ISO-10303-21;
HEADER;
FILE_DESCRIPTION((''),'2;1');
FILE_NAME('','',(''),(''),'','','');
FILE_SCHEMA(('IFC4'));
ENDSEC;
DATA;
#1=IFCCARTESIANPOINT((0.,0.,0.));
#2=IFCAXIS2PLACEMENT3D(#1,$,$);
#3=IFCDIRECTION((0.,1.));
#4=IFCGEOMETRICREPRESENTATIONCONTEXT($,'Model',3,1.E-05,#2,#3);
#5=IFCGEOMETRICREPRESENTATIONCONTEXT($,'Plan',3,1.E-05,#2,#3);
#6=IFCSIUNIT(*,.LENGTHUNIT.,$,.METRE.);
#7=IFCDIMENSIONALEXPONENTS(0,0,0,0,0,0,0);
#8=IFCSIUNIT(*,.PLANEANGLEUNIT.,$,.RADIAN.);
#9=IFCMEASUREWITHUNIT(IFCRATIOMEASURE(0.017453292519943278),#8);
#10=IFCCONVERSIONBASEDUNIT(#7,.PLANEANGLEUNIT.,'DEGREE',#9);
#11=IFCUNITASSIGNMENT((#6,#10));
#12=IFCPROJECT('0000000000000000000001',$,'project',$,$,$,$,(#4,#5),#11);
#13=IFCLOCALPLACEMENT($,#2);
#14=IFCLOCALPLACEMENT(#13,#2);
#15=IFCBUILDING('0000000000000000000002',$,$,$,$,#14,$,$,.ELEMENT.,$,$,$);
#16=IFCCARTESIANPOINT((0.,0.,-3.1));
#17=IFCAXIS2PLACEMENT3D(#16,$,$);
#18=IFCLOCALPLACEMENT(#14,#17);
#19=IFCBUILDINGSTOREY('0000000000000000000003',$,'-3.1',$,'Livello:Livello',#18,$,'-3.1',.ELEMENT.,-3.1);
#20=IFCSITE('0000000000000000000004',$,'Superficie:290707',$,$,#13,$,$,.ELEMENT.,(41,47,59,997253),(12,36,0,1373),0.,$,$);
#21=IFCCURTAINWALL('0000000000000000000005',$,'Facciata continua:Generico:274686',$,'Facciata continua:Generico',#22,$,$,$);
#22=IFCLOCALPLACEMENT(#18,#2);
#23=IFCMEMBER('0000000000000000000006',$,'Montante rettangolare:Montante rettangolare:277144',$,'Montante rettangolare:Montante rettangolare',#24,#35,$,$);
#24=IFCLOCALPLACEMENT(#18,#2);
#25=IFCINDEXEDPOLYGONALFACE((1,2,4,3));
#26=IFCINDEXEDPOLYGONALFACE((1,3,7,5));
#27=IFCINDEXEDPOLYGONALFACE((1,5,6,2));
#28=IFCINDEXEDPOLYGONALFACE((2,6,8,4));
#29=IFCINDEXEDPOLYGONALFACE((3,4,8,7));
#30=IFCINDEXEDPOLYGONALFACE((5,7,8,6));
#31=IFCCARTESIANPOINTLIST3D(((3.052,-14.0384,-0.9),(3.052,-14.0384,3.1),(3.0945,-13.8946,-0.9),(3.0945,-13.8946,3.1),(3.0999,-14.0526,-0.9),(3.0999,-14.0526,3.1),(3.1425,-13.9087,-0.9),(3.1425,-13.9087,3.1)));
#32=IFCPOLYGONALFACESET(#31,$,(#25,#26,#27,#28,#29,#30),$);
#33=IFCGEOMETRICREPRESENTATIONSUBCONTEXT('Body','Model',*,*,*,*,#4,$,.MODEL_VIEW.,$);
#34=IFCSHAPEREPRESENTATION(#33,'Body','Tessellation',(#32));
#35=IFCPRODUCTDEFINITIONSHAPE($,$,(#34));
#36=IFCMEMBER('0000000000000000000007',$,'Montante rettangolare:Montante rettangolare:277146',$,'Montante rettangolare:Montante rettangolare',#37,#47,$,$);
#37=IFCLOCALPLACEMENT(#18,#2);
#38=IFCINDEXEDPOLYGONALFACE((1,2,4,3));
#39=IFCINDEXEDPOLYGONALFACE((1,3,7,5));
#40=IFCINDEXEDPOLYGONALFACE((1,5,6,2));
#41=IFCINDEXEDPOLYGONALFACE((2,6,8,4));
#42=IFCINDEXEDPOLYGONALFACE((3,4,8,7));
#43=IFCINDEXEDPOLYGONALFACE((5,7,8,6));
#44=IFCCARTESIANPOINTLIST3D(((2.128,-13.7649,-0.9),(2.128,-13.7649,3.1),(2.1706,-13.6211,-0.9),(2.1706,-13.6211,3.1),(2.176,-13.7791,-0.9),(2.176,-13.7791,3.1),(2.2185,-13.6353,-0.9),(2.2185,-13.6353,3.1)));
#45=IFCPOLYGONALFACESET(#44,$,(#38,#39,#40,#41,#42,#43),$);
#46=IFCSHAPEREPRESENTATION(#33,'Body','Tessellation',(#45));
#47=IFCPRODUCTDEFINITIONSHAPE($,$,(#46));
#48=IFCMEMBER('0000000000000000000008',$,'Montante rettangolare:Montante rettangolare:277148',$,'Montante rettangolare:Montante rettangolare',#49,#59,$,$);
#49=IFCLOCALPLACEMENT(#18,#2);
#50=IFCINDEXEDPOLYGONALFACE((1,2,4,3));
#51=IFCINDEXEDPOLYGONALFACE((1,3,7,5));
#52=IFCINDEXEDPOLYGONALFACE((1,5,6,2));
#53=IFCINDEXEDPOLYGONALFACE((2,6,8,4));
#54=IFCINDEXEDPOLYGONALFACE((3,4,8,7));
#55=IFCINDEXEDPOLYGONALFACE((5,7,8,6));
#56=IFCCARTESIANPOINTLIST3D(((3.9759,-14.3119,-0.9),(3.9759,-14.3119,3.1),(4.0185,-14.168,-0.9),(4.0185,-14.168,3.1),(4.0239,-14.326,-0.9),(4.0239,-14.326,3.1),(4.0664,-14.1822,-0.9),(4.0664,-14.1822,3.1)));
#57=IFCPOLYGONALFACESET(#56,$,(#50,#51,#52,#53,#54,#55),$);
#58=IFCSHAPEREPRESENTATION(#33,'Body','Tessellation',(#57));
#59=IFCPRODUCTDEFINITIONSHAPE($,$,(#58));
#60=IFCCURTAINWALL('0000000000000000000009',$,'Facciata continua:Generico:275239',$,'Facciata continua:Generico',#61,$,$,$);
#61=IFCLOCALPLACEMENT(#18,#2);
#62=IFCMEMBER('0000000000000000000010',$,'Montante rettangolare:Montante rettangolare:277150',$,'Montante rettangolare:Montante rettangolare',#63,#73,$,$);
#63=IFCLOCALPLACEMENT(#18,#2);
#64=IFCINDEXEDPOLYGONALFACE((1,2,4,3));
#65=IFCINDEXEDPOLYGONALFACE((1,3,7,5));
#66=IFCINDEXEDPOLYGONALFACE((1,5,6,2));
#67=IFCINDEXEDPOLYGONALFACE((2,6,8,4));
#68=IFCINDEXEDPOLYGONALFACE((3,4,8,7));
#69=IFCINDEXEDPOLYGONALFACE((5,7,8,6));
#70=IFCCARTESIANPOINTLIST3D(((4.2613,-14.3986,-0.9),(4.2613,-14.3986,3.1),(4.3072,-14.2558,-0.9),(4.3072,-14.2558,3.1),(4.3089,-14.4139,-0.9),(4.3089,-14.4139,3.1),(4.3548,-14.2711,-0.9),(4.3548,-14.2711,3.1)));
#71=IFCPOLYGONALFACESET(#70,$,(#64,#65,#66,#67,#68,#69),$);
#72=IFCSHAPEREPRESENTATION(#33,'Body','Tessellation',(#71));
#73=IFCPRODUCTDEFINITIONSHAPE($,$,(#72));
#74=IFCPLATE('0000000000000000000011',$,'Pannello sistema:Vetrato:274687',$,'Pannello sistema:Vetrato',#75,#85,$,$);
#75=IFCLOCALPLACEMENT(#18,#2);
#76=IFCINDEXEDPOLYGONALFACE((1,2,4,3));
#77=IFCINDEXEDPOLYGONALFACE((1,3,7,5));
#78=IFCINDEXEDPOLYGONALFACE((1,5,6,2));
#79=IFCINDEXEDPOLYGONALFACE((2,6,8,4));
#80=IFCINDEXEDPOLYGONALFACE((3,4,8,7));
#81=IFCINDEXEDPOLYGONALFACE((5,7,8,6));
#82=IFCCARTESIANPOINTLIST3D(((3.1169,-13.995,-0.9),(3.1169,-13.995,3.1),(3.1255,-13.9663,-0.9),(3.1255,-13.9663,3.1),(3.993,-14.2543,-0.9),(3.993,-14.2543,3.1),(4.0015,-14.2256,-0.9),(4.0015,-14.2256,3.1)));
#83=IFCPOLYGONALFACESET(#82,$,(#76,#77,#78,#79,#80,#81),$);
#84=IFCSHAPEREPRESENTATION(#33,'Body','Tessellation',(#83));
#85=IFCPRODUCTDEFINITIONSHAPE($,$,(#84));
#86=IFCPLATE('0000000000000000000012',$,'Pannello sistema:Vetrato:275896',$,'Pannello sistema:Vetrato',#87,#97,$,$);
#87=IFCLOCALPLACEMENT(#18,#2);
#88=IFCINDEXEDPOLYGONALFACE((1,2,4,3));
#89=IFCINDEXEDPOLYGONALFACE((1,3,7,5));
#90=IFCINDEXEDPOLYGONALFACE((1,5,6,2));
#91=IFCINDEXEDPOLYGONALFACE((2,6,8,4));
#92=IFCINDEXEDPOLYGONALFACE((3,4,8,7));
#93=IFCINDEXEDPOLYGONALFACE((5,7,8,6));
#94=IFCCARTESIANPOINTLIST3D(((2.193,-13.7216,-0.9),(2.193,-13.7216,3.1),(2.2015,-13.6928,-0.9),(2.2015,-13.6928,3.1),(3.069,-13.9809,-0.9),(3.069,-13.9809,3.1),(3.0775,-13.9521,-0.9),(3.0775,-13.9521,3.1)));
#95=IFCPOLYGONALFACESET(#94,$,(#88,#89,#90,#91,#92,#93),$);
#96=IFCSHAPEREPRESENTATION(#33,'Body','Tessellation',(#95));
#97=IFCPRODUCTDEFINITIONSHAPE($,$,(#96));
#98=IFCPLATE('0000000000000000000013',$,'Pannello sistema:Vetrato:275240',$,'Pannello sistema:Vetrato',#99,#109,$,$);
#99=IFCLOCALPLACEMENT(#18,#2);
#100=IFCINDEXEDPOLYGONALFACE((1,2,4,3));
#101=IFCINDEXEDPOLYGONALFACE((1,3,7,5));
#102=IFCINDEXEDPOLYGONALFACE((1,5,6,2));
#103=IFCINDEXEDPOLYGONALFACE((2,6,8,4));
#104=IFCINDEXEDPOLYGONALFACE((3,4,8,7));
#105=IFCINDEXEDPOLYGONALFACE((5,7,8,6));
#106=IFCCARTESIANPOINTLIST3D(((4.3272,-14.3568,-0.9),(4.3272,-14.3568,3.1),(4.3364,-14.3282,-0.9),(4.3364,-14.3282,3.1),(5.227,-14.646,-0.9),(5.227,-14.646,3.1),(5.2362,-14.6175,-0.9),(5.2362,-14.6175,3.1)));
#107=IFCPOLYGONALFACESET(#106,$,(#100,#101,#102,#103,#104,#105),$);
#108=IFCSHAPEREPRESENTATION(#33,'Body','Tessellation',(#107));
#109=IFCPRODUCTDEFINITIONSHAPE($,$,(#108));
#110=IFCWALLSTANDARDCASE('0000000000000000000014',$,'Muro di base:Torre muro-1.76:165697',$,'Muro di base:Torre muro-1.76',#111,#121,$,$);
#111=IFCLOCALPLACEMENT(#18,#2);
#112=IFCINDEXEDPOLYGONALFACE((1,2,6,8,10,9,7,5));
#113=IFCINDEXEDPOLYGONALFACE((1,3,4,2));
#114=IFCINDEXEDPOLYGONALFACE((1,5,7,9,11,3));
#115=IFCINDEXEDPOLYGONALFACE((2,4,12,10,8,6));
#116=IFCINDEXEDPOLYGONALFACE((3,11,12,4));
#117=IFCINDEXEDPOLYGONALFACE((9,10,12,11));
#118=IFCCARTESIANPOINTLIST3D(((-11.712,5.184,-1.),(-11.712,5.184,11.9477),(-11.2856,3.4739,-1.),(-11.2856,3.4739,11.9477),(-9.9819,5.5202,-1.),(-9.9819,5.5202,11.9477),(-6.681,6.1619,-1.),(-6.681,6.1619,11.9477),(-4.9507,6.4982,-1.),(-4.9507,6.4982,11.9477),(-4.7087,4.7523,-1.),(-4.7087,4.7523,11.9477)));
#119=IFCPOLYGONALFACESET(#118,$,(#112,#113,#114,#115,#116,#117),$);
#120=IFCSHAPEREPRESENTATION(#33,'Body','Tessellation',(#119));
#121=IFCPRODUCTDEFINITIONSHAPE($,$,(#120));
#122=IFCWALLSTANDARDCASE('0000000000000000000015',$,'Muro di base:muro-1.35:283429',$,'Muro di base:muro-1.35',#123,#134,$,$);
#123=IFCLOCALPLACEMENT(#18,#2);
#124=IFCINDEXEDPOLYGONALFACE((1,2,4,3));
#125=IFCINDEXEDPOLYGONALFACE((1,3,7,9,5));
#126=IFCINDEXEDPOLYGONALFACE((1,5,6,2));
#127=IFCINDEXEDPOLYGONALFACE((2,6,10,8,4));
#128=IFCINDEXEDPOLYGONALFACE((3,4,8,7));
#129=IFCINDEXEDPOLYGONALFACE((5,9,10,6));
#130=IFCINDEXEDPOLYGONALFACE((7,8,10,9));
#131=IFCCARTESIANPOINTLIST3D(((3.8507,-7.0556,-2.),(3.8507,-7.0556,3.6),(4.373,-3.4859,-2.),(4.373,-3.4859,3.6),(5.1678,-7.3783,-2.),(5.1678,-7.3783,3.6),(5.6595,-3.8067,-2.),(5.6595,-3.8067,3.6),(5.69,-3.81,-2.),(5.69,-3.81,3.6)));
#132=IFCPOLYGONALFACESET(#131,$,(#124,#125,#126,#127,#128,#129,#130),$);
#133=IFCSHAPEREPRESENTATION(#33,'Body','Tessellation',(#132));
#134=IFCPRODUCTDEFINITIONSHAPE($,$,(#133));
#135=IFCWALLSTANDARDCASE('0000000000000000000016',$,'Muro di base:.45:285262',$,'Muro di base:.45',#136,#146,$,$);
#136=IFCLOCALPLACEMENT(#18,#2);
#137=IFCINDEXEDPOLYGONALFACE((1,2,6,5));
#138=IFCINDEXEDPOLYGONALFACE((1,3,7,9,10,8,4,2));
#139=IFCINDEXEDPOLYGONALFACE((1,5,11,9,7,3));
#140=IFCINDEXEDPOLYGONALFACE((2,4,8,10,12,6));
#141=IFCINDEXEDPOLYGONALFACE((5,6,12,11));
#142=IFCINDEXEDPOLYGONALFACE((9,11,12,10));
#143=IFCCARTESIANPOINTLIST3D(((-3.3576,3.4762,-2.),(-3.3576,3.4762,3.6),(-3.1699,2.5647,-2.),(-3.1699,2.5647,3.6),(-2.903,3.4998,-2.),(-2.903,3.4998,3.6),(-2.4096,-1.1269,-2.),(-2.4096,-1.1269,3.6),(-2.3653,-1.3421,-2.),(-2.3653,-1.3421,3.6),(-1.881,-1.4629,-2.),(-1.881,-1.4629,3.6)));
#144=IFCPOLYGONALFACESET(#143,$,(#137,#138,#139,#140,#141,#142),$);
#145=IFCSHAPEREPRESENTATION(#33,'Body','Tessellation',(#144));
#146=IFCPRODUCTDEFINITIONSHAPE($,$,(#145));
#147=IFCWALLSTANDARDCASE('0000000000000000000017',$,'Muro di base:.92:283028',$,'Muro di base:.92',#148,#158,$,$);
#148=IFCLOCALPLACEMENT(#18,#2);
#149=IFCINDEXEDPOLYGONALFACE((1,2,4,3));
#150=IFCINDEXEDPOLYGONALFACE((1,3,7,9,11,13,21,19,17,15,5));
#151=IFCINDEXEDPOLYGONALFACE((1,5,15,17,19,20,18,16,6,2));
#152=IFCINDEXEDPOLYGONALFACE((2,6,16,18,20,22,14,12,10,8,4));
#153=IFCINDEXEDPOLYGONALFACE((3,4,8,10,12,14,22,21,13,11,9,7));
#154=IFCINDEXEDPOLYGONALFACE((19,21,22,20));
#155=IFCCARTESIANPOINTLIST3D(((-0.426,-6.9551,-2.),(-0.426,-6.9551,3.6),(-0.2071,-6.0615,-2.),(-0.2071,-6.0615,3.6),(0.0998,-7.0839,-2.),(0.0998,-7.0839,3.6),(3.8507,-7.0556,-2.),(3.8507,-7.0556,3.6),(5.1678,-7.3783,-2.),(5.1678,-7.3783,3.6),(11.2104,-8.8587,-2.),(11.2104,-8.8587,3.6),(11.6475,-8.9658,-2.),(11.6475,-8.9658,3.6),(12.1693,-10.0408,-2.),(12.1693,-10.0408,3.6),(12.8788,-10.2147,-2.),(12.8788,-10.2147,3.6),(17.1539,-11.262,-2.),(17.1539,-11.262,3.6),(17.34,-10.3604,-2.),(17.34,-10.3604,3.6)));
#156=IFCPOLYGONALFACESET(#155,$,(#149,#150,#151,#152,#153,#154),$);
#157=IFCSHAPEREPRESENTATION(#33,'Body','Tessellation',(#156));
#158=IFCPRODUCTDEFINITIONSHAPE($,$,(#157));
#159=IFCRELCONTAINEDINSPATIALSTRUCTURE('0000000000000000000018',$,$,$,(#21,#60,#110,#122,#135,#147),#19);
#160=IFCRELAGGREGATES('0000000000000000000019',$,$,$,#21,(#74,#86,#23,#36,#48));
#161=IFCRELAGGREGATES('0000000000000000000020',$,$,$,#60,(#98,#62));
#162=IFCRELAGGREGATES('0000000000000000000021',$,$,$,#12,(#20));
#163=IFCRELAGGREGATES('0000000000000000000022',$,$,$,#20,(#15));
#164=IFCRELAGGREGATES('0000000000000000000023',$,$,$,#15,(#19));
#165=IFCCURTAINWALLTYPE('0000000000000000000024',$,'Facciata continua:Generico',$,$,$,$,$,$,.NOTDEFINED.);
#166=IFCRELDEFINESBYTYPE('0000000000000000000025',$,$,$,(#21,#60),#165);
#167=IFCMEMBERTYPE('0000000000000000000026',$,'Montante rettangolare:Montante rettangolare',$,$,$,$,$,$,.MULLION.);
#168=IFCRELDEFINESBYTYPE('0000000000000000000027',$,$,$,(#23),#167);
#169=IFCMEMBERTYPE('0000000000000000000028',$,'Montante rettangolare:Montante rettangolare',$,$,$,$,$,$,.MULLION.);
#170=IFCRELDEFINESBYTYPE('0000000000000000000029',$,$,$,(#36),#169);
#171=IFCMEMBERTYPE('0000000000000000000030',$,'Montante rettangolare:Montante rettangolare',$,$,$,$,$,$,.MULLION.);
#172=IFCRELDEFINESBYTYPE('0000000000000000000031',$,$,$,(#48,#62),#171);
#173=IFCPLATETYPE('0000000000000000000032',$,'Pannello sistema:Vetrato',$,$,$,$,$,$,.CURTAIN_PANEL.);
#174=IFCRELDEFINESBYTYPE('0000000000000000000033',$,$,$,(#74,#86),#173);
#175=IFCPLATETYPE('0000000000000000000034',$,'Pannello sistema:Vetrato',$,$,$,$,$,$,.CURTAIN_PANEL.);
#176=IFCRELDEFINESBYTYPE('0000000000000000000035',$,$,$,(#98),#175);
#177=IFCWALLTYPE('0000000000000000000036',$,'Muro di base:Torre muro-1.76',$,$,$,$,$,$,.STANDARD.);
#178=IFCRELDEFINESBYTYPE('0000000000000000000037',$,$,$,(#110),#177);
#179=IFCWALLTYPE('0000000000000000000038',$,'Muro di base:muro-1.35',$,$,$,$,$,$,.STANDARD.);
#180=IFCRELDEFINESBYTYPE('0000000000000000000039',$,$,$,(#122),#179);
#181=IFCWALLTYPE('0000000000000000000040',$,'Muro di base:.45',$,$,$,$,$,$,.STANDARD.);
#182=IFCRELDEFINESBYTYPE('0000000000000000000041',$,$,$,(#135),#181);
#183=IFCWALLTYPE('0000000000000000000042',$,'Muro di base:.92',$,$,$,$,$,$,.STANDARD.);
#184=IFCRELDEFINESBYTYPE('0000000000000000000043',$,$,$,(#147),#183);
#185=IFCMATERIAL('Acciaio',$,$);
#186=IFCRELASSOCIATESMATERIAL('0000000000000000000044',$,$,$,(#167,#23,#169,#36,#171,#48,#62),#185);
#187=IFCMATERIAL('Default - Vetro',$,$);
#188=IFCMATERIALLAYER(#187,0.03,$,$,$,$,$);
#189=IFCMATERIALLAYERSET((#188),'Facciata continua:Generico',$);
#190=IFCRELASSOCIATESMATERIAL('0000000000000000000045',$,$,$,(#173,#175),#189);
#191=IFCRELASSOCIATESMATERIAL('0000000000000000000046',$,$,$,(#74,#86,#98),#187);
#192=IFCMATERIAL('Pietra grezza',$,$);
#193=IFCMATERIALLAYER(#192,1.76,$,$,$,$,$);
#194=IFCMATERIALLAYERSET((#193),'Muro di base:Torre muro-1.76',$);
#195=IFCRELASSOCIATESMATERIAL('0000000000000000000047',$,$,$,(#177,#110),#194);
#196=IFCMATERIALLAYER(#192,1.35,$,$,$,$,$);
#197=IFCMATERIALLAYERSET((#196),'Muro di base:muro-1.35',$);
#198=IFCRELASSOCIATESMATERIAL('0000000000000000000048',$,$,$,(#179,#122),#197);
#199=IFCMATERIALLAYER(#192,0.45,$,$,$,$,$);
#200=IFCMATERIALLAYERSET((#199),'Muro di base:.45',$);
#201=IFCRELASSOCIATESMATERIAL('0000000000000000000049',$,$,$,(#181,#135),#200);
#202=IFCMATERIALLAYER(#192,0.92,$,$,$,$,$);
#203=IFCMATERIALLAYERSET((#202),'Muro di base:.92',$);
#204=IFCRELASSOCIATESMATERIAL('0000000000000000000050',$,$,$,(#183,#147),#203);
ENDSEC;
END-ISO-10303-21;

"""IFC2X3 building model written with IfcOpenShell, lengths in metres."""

from ifc_helpers import new_model, entity, si_unit, converted_unit, direction, frame, frame_2d, origin, origin_2d_with_axis, place, context, subcontext, project, spatial, polyline, rectangle, outline, extrude, source, transform, mapped, material, layer, layer_set, layer_usage, type_object, type_shapes, element, aggregate, save


model = new_model("IFC2X3")

# Units and contexts
model_context = context("Model", 3, precision=1e-05, world=origin(), true_north=direction((0.0, 1.0)))
plan_context = context("Plan", 3, precision=1e-05, world=origin(), true_north=direction((0.0, 1.0)))
body_context = subcontext(model_context, "Body", "Model", "MODEL_VIEW")
ifc_project = project(units=[si_unit("LENGTHUNIT", "METRE"), converted_unit("PLANEANGLEUNIT", "DEGREE", entity("IfcRatioMeasure", 0.017453292519943278), si_unit("PLANEANGLEUNIT", "RADIAN"), dimensions=[0, 0, 0, 0, 0, 0, 0])], contexts=[model_context, plan_context])

# Site, building, storey
site_placement = place(None, origin())
site = spatial("IfcSite", under=ifc_project, at=site_placement, Name="Superficie:290707", CompositionType="ELEMENT", RefLatitude=(41, 47, 59, 997253), RefLongitude=(12, 36, 0, 1373), RefElevation=0.0)
building_placement = place(site_placement, origin())
building = spatial("IfcBuilding", under=site, at=building_placement, CompositionType="ELEMENT")
storey_placement = place(building_placement, frame((0.0, 0.0, -3.1)))
storey = spatial("IfcBuildingStorey", under=building, at=storey_placement, Name="-3.1", ObjectType="Livello:Livello", LongName="-3.1", CompositionType="ELEMENT", Elevation=-3.1)

# Curtain wall, members
curtain_wall_type = type_object("IfcCurtainWallType", Name="Facciata continua:Generico", PredefinedType="NOTDEFINED")
curtain_wall_1_placement = place(storey_placement, frame((0.0, 0.0, 3.1)))
curtain_wall_1 = element("IfcCurtainWall", 1, at=curtain_wall_1_placement, inside=storey, type_object=curtain_wall_type, Name="Facciata continua:Generico:274686", ObjectType="Facciata continua:Generico")
ifc_material_1 = material(Name="Acciaio")
member_type_1 = type_object("IfcMemberType", Name="Montante rettangolare:Montante rettangolare", PredefinedType="MULLION", material=ifc_material_1)
shared_shape_1 = source(origin(), body_context, "Body", "SweptSolid", [
    extrude(rectangle(XDim=0.15, YDim=0.05, at=origin_2d_with_axis()), frame((0.0, 0.0, -4.0), z_axis=(0.0, 0.0, 1.0), x_axis=(0.0, -1.0, 0.0)), (0.0, 0.0, 1.0), 4.0),
])
type_shapes(member_type_1, [shared_shape_1])
member_1_placement = place(curtain_wall_1_placement, frame((3.0972, -13.9736, -4.0), z_axis=(0.0, 0.0, -1.0), x_axis=(-0.958882, 0.283805, 0.0)))
member_1 = element("IfcMember", 2, at=member_1_placement, type_object=member_type_1, material=ifc_material_1, Name="Montante rettangolare:Montante rettangolare:277144", ObjectType="Montante rettangolare:Montante rettangolare", context=body_context, shape_type="MappedRepresentation", body=[
    mapped(shared_shape_1, transform((0.0, 0.0, 0.0), scale=1.0)),
])
member_type_2 = type_object("IfcMemberType", Name="Montante rettangolare:Montante rettangolare", PredefinedType="MULLION", material=ifc_material_1)
shared_shape_2 = source(origin(), body_context, "Body", "SweptSolid", [
    extrude(rectangle(XDim=0.15, YDim=0.05, at=origin_2d_with_axis()), frame((-0.025, 0.0, -4.0), z_axis=(0.0, 0.0, 1.0), x_axis=(0.0, -1.0, 0.0)), (0.0, 0.0, 1.0), 4.0),
])
type_shapes(member_type_2, [shared_shape_2])
member_2_placement = place(curtain_wall_1_placement, frame((2.1493, -13.693, -4.0), z_axis=(0.0, 0.0, -1.0), x_axis=(-0.958882, 0.283805, 0.0)))
member_2 = element("IfcMember", 3, at=member_2_placement, type_object=member_type_2, material=ifc_material_1, Name="Montante rettangolare:Montante rettangolare:277146", ObjectType="Montante rettangolare:Montante rettangolare", context=body_context, shape_type="MappedRepresentation", body=[
    mapped(shared_shape_2, transform((0.0, 0.0, 0.0), scale=1.0)),
])
member_type_3 = type_object("IfcMemberType", Name="Montante rettangolare:Montante rettangolare", PredefinedType="MULLION", material=ifc_material_1)
shared_shape_3 = source(origin(), body_context, "Body", "SweptSolid", [
    extrude(rectangle(XDim=0.15, YDim=0.05, at=origin_2d_with_axis()), frame((-0.025, 0.0, -4.0), z_axis=(0.0, 0.0, 1.0), x_axis=(0.0, -1.0, 0.0)), (0.0, 0.0, 1.0), 4.0),
])
type_shapes(member_type_3, [shared_shape_3])
member_3_placement = place(curtain_wall_1_placement, frame((4.0452, -14.2541, 0.0), z_axis=(0.0, 0.0, 1.0), x_axis=(0.958882, -0.283805, 0.0)))
member_3 = element("IfcMember", 4, at=member_3_placement, type_object=member_type_3, material=ifc_material_1, Name="Montante rettangolare:Montante rettangolare:277148", ObjectType="Montante rettangolare:Montante rettangolare", context=body_context, shape_type="MappedRepresentation", body=[
    mapped(shared_shape_3, transform((0.0, 0.0, 0.0), scale=1.0)),
])

# Curtain wall, member
curtain_wall_2_placement = place(storey_placement, frame((0.0, 0.0, 3.1)))
curtain_wall_2 = element("IfcCurtainWall", 5, at=curtain_wall_2_placement, inside=storey, type_object=curtain_wall_type, Name="Facciata continua:Generico:275239", ObjectType="Facciata continua:Generico")
member_4_placement = place(curtain_wall_2_placement, frame((4.2842, -14.3272, 0.0), z_axis=(0.0, 0.0, 1.0), x_axis=(-0.952025, 0.30602, 0.0)))
member_4 = element("IfcMember", 6, at=member_4_placement, type_object=member_type_3, material=ifc_material_1, Name="Montante rettangolare:Montante rettangolare:277150", ObjectType="Montante rettangolare:Montante rettangolare", context=body_context, shape_type="MappedRepresentation", body=[
    mapped(shared_shape_3, transform((0.0, 0.0, 0.0), scale=1.0)),
])

# Plates
ifc_material_2 = material(Name="Default - Vetro")
ifc_layer_1 = layer(ifc_material_2, 0.03)
ifc_layer_set_1 = layer_set([ifc_layer_1], Name="Facciata continua:Generico")
plate_type_1 = type_object("IfcPlateType", Name="Pannello sistema:Vetrato", PredefinedType="CURTAIN_PANEL", material=ifc_layer_set_1)
shared_shape_4 = source(origin(), body_context, "Body", "SweptSolid", [
    extrude(rectangle(XDim=0.03, YDim=0.9136, at=frame_2d((0.0, 0.0), x_axis=(1.0, 0.0))), frame((0.0, 0.0, 0.0), z_axis=(0.0, 0.0, 1.0), x_axis=(0.0, 1.0, 0.0)), (0.0, 0.0, 1.0), 4.0),
])
type_shapes(plate_type_1, [shared_shape_4])
plate_1_placement = place(curtain_wall_1_placement, frame((3.5592, -14.1103, -4.0), z_axis=(0.0, 0.0, 1.0), x_axis=(-0.958882, 0.283805, 0.0)))
plate_1 = element("IfcPlate", 7, at=plate_1_placement, type_object=plate_type_1, material=ifc_material_2, Name="Pannello sistema:Vetrato:274687", ObjectType="Pannello sistema:Vetrato", context=body_context, shape_type="MappedRepresentation", body=[
    mapped(shared_shape_4, transform((0.0, 0.0, 0.0), scale=1.0)),
])
plate_2_placement = place(curtain_wall_1_placement, frame((2.6353, -13.8368, -4.0), z_axis=(0.0, 0.0, 1.0), x_axis=(-0.958882, 0.283805, 0.0)))
plate_2 = element("IfcPlate", 8, at=plate_2_placement, type_object=plate_type_1, material=ifc_material_2, Name="Pannello sistema:Vetrato:275896", ObjectType="Pannello sistema:Vetrato", context=body_context, shape_type="MappedRepresentation", body=[
    mapped(shared_shape_4, transform((0.0, 0.0, 0.0), scale=1.0)),
])
aggregate(curtain_wall_1, [plate_1, plate_2, member_1, member_2, member_3])
plate_type_2 = type_object("IfcPlateType", Name="Pannello sistema:Vetrato", PredefinedType="CURTAIN_PANEL", material=ifc_layer_set_1)
shared_shape_5 = source(origin(), body_context, "Body", "SweptSolid", [
    extrude(rectangle(XDim=0.03, YDim=0.9451, at=frame_2d((0.0, 0.0), x_axis=(1.0, 0.0))), frame((0.0, 0.0, 0.0), z_axis=(0.0, 0.0, 1.0), x_axis=(0.0, 1.0, 0.0)), (0.0, 0.0, 1.0), 4.0),
])
type_shapes(plate_type_2, [shared_shape_5])
plate_3_placement = place(curtain_wall_2_placement, frame((4.7817, -14.4871, -4.0), z_axis=(0.0, 0.0, 1.0), x_axis=(0.952025, -0.30602, 0.0)))
plate_3 = element("IfcPlate", 9, at=plate_3_placement, type_object=plate_type_2, material=ifc_material_2, Name="Pannello sistema:Vetrato:275240", ObjectType="Pannello sistema:Vetrato", context=body_context, shape_type="MappedRepresentation", body=[
    mapped(shared_shape_5, transform((0.0, 0.0, 0.0), scale=1.0)),
])
aggregate(curtain_wall_2, [plate_3, member_4])

# Walls
ifc_material_3 = material(Name="Pietra grezza")
ifc_layer_2 = layer(ifc_material_3, 1.76)
ifc_layer_set_2 = layer_set([ifc_layer_2], Name="Muro di base:Torre muro-1.76")
ifc_layer_usage_1 = layer_usage(ifc_layer_set_2, "AXIS2", "POSITIVE", -0.88)
wall_type_1 = type_object("IfcWallType", Name="Muro di base:Torre muro-1.76", PredefinedType="STANDARD", material=ifc_layer_set_2)
wall_1_placement = place(storey_placement, frame((-11.544, 4.3201, -1.0), z_axis=(0.0, 0.0, 1.0), x_axis=(0.981627, 0.190809, 0.0)))
element("IfcWallStandardCase", 10, at=wall_1_placement, inside=storey, type_object=wall_type_1, material=ifc_layer_usage_1, Name="Muro di base:Torre muro-1.76:165697", ObjectType="Muro di base:Torre muro-1.76", context=body_context, shape_type="SweptSolid", body=[
    extrude(outline(polyline([(6.7922, -0.88), (6.8878, 0.88), (5.1252, 0.88), (1.7624, 0.88), (0.0, 0.88), (0.0922, -0.88), (6.7922, -0.88)])), origin(), (0.0, 0.0, 1.0), 12.9477),
])
ifc_layer_3 = layer(ifc_material_3, 1.35)
ifc_layer_set_3 = layer_set([ifc_layer_3], Name="Muro di base:muro-1.35")
ifc_layer_usage_2 = layer_usage(ifc_layer_set_3, "AXIS2", "NEGATIVE", 0.675)
wall_type_2 = type_object("IfcWallType", Name="Muro di base:muro-1.35", PredefinedType="STANDARD", material=ifc_layer_set_3)
wall_2_placement = place(storey_placement, frame((4.5, -7.2806, -2.0), z_axis=(0.0, 0.0, 1.0), x_axis=(0.144778, 0.989464, 0.0)))
element("IfcWallStandardCase", 11, at=wall_2_placement, inside=storey, type_object=wall_type_2, material=ifc_layer_usage_2, Name="Muro di base:muro-1.35:283429", ObjectType="Muro di base:muro-1.35", context=body_context, shape_type="SweptSolid", body=[
    extrude(outline(polyline([(3.6063, -0.675), (3.6052, -0.6444), (3.7363, 0.675), (0.1286, 0.675), (0.0, -0.675), (3.6063, -0.675)])), origin(), (0.0, 0.0, 1.0), 5.6),
])
ifc_layer_4 = layer(ifc_material_3, 0.45)
ifc_layer_set_4 = layer_set([ifc_layer_4], Name="Muro di base:.45")
wall_type_3 = type_object("IfcWallType", Name="Muro di base:.45", PredefinedType="STANDARD", material=ifc_layer_set_4)
ifc_layer_usage_3 = layer_usage(ifc_layer_set_4, "AXIS2", "POSITIVE", -0.225)
wall_3_placement = place(storey_placement, frame((-2.1014, -1.5082, -2.0), z_axis=(0.0, 0.0, 1.0), x_axis=(-0.201705, 0.979446, 0.0)))
element("IfcWallStandardCase", 12, at=wall_3_placement, inside=storey, type_object=wall_type_3, material=ifc_layer_usage_3, Name="Muro di base:.45:285262", ObjectType="Muro di base:.45", context=body_context, shape_type="SweptSolid", body=[
    extrude(outline(polyline([(5.0668, -0.225), (5.1353, 0.225), (4.2047, 0.225), (0.4357, 0.225), (0.216, 0.225), (0.0, -0.225), (5.0668, -0.225)])), origin(), (0.0, 0.0, 1.0), 5.6),
])
ifc_layer_5 = layer(ifc_material_3, 0.92)
ifc_layer_set_5 = layer_set([ifc_layer_5], Name="Muro di base:.92")
ifc_layer_usage_4 = layer_usage(ifc_layer_set_5, "AXIS2", "POSITIVE", -0.46)
wall_type_4 = type_object("IfcWallType", Name="Muro di base:.92", PredefinedType="STANDARD", material=ifc_layer_set_5)
wall_4_placement = place(storey_placement, frame((-0.3165, -6.5083, -2.0), z_axis=(0.0, 0.0, 1.0), x_axis=(0.971276, -0.237955, 0.0)))
element("IfcWallStandardCase", 13, at=wall_4_placement, inside=storey, type_object=wall_type_4, material=ifc_layer_usage_4, Name="Muro di base:.92:283028", ObjectType="Muro di base:.92", context=body_context, shape_type="SweptSolid", body=[
    extrude(outline(polyline([(18.0998, -0.46), (18.0659, 0.46), (12.2052, 0.46), (11.7552, 0.46), (5.5338, 0.46), (4.1777, 0.46), (0.0, 0.46), (0.0, -0.46), (0.5413, -0.46), (12.9677, -0.46), (13.6982, -0.46), (18.0998, -0.46)])), origin(), (0.0, 0.0, 1.0), 5.6),
])

save(model, "model.ifc")
